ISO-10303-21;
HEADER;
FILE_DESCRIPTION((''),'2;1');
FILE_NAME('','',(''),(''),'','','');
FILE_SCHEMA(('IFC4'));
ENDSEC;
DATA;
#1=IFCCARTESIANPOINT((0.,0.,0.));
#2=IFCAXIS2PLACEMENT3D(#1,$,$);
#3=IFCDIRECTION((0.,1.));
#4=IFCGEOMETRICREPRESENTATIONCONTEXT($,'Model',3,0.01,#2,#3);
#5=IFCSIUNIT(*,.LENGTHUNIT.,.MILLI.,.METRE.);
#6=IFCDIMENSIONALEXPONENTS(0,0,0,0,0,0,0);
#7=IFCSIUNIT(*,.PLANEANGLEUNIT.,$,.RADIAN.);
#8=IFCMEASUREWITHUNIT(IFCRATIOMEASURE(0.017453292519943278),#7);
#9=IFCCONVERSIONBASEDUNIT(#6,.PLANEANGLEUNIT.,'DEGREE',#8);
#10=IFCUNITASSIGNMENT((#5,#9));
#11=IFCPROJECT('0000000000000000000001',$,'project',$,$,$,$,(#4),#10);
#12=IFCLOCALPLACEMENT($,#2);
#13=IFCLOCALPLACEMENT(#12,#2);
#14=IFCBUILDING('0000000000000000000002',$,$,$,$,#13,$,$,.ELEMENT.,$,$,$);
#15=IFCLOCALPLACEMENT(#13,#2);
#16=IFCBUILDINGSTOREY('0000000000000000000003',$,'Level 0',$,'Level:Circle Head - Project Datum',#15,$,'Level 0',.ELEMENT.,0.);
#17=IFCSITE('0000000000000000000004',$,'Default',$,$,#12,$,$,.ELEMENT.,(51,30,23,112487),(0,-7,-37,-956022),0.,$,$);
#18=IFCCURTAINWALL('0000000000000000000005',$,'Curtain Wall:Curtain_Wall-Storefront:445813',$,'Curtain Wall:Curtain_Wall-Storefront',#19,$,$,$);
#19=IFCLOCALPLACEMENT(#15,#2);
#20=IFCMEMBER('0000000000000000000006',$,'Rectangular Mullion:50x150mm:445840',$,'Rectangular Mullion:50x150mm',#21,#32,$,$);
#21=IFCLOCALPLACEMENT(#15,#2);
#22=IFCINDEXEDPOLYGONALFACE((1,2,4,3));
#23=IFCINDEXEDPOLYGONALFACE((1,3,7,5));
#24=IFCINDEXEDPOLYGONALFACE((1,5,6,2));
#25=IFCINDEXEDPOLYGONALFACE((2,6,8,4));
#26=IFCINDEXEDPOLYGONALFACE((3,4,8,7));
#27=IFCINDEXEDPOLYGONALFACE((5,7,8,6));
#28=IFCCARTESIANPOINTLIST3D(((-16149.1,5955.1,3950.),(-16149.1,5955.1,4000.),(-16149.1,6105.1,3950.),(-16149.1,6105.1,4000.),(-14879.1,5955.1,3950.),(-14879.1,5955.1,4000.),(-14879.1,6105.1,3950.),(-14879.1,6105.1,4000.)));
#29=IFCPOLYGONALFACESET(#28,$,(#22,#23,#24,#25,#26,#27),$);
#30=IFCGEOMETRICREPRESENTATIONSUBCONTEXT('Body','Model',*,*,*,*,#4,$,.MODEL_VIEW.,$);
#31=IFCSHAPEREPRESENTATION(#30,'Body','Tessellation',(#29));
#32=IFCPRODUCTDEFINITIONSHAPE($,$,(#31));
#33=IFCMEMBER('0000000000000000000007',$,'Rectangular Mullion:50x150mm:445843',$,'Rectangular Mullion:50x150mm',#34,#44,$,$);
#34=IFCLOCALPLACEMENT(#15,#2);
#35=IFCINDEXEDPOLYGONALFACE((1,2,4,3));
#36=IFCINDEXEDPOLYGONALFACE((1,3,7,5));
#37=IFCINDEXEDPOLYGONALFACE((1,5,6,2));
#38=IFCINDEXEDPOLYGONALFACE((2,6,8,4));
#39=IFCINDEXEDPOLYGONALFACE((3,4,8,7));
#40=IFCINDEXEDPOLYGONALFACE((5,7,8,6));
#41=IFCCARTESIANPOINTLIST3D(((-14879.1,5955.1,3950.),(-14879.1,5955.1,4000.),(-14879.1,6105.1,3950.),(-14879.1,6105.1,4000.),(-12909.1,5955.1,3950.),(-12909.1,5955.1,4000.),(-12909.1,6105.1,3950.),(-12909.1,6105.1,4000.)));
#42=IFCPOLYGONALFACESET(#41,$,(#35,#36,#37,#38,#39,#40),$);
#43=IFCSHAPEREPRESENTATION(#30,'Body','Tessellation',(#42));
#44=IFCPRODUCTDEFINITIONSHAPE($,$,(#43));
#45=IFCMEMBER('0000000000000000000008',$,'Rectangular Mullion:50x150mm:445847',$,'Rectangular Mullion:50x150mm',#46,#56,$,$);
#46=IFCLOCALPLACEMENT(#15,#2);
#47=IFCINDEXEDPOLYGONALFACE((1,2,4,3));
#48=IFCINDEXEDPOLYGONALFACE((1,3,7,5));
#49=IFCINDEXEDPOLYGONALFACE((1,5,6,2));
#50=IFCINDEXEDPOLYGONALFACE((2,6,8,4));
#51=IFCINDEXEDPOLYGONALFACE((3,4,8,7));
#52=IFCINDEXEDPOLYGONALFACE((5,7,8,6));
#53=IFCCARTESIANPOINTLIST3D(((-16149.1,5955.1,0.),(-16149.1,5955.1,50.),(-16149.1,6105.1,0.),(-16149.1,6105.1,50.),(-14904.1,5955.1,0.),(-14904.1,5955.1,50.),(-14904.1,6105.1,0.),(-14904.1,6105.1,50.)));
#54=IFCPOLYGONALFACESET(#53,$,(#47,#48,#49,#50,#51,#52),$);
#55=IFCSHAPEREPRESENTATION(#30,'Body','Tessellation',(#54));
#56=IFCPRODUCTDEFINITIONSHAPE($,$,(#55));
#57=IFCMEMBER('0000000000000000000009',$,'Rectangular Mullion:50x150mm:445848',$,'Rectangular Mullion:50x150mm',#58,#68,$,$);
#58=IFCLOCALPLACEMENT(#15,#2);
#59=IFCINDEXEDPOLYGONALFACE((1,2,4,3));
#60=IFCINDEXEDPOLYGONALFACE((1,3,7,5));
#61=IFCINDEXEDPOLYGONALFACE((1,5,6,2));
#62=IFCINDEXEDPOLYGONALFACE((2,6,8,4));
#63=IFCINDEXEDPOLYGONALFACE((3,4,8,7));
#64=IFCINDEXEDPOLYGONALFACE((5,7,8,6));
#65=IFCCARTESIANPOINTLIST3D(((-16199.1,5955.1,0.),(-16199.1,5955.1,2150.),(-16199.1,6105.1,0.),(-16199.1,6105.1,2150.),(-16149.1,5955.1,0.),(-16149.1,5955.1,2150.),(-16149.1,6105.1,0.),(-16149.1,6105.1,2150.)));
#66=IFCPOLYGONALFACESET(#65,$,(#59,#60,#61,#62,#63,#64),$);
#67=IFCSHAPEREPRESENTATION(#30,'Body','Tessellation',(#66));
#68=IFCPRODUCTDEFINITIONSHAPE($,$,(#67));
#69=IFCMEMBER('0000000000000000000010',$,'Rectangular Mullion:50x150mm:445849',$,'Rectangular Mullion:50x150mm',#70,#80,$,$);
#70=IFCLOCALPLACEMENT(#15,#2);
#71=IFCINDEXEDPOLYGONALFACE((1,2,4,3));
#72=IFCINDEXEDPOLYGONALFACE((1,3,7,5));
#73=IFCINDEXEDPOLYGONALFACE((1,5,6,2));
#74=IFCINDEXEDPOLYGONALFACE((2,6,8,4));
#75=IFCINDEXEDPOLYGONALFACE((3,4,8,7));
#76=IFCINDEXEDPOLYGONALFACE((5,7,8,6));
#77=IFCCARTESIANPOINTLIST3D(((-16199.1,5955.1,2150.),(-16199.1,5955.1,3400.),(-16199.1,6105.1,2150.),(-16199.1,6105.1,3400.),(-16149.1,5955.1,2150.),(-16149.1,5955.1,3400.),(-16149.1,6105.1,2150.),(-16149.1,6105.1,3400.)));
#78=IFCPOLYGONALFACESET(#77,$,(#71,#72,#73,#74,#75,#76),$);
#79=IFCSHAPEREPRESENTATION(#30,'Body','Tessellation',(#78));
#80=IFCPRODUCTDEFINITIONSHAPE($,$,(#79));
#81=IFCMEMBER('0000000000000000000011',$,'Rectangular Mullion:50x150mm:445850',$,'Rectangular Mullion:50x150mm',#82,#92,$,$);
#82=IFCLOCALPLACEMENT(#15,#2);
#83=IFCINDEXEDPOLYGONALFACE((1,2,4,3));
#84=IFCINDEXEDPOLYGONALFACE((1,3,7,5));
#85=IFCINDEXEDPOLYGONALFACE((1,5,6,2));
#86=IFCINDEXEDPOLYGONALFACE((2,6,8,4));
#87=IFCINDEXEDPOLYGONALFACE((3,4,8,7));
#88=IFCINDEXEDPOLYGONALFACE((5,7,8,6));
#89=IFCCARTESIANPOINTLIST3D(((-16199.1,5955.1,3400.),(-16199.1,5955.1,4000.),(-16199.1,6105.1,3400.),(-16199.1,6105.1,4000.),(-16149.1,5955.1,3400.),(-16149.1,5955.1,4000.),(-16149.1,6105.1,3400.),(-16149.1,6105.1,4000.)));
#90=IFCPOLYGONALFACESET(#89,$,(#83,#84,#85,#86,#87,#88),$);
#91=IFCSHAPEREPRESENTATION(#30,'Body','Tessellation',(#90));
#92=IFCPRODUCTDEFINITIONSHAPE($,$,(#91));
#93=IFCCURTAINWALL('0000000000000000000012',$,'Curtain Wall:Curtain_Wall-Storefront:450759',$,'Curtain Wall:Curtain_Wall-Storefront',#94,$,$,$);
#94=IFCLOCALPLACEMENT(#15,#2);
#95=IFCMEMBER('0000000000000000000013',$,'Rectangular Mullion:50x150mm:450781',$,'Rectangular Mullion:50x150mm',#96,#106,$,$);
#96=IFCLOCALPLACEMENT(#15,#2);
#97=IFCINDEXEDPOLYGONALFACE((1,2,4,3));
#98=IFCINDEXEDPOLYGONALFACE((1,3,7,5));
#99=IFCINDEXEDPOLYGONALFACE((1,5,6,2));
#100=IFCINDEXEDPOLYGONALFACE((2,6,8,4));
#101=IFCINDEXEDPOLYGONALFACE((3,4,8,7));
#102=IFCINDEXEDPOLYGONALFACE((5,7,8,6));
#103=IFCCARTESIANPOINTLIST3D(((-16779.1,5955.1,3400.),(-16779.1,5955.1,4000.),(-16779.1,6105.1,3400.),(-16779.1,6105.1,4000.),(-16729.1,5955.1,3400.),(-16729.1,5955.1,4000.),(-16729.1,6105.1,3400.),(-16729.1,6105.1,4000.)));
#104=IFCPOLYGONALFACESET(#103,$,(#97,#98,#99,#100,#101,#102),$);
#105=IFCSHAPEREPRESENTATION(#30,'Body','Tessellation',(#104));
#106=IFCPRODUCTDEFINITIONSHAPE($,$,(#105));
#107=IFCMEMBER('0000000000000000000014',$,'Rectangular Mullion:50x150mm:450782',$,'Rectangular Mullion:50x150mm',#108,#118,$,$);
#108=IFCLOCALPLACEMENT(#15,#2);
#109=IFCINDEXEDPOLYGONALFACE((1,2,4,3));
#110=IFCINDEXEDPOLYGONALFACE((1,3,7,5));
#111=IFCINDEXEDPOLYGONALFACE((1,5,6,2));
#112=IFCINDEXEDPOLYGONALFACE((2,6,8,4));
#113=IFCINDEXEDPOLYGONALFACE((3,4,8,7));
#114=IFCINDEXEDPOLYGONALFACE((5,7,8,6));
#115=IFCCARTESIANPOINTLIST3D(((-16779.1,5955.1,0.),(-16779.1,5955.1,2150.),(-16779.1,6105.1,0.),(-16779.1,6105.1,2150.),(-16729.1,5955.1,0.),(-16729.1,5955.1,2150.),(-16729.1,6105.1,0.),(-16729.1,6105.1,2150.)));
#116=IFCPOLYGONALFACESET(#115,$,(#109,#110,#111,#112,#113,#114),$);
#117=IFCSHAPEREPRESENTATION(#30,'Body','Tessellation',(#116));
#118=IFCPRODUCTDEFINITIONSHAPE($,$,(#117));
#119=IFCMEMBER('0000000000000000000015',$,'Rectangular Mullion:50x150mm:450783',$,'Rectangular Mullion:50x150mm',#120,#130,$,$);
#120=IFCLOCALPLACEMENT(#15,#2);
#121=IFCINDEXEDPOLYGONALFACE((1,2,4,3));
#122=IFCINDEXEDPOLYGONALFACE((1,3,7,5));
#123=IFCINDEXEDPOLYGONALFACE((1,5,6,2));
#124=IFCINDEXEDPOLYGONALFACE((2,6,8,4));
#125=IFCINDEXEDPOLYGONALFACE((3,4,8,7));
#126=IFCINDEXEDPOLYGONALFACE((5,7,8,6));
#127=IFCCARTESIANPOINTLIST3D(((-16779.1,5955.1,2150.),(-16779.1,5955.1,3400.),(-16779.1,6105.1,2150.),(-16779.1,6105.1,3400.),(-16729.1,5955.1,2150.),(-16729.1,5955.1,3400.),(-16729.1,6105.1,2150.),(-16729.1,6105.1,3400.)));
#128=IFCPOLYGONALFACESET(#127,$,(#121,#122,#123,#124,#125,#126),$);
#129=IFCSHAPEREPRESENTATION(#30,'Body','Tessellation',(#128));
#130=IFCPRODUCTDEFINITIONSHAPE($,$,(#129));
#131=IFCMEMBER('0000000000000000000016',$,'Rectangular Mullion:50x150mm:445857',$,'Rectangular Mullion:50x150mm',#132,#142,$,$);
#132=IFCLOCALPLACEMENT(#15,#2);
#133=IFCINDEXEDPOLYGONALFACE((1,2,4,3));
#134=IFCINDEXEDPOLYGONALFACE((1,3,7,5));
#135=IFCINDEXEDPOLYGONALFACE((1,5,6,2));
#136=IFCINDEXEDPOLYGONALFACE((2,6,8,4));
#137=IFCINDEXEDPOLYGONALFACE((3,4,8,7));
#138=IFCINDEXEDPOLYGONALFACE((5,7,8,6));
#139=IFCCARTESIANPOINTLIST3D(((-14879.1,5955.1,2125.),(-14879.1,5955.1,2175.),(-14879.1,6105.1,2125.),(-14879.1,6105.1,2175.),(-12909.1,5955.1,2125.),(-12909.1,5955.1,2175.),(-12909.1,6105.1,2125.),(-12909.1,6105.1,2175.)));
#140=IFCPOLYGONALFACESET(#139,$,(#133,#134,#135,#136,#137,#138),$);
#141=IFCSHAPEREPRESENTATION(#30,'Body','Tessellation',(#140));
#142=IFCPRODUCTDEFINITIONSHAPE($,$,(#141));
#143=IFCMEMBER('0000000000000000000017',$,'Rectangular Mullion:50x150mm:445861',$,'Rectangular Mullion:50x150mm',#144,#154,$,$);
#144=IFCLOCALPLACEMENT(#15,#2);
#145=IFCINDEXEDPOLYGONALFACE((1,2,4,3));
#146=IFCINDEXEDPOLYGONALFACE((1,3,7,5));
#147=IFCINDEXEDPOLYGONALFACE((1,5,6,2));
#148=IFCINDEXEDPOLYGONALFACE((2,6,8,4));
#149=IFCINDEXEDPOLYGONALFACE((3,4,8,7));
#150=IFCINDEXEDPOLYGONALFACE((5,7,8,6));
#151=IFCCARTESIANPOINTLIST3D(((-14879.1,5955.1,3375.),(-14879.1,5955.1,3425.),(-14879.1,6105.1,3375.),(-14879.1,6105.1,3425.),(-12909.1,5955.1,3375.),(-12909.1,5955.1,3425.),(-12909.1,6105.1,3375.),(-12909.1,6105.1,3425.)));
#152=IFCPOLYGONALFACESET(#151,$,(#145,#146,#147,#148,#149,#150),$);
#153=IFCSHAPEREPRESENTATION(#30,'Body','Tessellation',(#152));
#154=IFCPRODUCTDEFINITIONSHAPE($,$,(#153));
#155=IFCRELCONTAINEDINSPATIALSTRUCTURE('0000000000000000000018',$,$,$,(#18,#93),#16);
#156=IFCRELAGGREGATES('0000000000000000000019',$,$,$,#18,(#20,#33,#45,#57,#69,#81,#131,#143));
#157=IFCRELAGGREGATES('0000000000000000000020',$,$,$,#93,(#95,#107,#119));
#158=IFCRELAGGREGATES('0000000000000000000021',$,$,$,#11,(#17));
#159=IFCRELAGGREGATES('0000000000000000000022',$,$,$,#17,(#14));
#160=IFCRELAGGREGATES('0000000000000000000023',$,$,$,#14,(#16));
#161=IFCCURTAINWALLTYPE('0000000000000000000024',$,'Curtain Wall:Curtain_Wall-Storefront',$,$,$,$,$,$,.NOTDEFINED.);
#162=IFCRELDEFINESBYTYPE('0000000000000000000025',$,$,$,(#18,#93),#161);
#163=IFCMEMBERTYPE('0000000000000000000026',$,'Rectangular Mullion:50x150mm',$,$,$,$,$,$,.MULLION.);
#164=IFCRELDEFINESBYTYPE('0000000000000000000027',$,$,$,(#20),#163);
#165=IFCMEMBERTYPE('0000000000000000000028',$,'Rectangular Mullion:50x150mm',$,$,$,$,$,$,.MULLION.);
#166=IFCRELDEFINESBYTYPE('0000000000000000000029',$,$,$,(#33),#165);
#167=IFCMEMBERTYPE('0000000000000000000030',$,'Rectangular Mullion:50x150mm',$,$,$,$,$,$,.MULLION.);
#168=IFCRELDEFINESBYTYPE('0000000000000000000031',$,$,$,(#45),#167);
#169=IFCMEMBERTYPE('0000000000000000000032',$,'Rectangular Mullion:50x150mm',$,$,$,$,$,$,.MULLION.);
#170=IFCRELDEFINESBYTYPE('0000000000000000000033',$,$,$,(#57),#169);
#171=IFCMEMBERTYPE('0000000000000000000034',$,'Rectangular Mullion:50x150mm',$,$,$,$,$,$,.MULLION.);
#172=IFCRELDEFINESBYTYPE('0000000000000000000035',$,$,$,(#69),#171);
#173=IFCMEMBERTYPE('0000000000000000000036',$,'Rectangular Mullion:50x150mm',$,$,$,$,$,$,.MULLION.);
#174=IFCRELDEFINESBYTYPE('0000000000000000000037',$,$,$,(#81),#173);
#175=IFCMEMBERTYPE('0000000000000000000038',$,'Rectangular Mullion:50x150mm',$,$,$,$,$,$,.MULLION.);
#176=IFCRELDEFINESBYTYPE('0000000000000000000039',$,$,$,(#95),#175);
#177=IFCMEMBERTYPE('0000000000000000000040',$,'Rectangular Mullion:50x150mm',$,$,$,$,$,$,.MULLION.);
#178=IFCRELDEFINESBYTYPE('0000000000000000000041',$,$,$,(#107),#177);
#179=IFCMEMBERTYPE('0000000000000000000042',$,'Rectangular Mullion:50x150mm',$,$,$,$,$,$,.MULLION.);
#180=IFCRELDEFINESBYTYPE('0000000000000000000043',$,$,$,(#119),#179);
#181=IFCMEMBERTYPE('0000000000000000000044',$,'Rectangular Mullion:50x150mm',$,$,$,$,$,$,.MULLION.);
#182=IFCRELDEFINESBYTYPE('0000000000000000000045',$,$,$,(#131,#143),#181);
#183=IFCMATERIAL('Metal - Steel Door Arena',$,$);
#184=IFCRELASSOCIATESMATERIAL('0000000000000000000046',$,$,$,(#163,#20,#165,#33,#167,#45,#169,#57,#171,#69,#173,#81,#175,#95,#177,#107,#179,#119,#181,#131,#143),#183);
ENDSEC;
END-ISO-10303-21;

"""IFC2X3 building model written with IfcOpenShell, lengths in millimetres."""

from ifc_helpers import new_model, entity, si_unit, converted_unit, direction, frame, origin, origin_2d_with_axis, place, context, subcontext, project, spatial, rectangle, extrude, source, transform, mapped, material, type_object, type_shapes, element, aggregate, save


model = new_model("IFC2X3")

# Units and contexts
model_context = context("Model", 3, precision=0.01, world=origin(), true_north=direction((0.0, 1.0)))
body_context = subcontext(model_context, "Body", "Model", "MODEL_VIEW")
ifc_project = project(units=[si_unit("LENGTHUNIT", "METRE", prefix="MILLI"), converted_unit("PLANEANGLEUNIT", "DEGREE", entity("IfcRatioMeasure", 0.017453292519943278), si_unit("PLANEANGLEUNIT", "RADIAN"), dimensions=[0, 0, 0, 0, 0, 0, 0])], contexts=[model_context])

# Site, building, storey
site_placement = place(None, origin())
site = spatial("IfcSite", under=ifc_project, at=site_placement, Name="Default", CompositionType="ELEMENT", RefLatitude=(51, 30, 23, 112487), RefLongitude=(0, -7, -37, -956022), RefElevation=0.0)
building_placement = place(site_placement, origin())
building = spatial("IfcBuilding", under=site, at=building_placement, CompositionType="ELEMENT")
storey_placement = place(building_placement, origin())
storey = spatial("IfcBuildingStorey", under=building, at=storey_placement, Name="Level 0", ObjectType="Level:Circle Head - Project Datum", LongName="Level 0", CompositionType="ELEMENT", Elevation=0.0)

# Curtain walls, members
curtain_wall_type = type_object("IfcCurtainWallType", Name="Curtain Wall:Curtain_Wall-Storefront", PredefinedType="NOTDEFINED")
curtain_wall_1_placement = place(storey_placement, origin())
curtain_wall_1 = element("IfcCurtainWall", 1, at=curtain_wall_1_placement, inside=storey, type_object=curtain_wall_type, Name="Curtain Wall:Curtain_Wall-Storefront:445813", ObjectType="Curtain Wall:Curtain_Wall-Storefront")
ifc_material_1 = material(Name="Metal - Steel Door Arena")
member_type_1 = type_object("IfcMemberType", Name="Rectangular Mullion:50x150mm", PredefinedType="MULLION", material=ifc_material_1)
shared_shape_1 = source(origin(), body_context, "Body", "SweptSolid", [
    extrude(rectangle(XDim=150.0, YDim=50.0, at=origin_2d_with_axis()), frame((-25.0, 0.0, -1270.0), z_axis=(0.0, 0.0, 1.0), x_axis=(0.0, -1.0, 0.0)), (0.0, 0.0, 1.0), 1270.0),
])
type_shapes(member_type_1, [shared_shape_1])
member_1_placement = place(curtain_wall_1_placement, frame((-16149.1, 6030.1, 4000.0), z_axis=(-1.0, 0.0, 0.0), x_axis=(0.0, 0.0, 1.0)))
member_1 = element("IfcMember", 2, at=member_1_placement, type_object=member_type_1, material=ifc_material_1, Name="Rectangular Mullion:50x150mm:445840", ObjectType="Rectangular Mullion:50x150mm", context=body_context, shape_type="MappedRepresentation", body=[
    mapped(shared_shape_1, transform((0.0, 0.0, 0.0), scale=1.0)),
])
member_type_2 = type_object("IfcMemberType", Name="Rectangular Mullion:50x150mm", PredefinedType="MULLION", material=ifc_material_1)
shared_shape_2 = source(origin(), body_context, "Body", "SweptSolid", [
    extrude(rectangle(XDim=150.0, YDim=50.0, at=origin_2d_with_axis()), frame((-25.0, 0.0, -1970.0), z_axis=(0.0, 0.0, 1.0), x_axis=(0.0, -1.0, 0.0)), (0.0, 0.0, 1.0), 1970.0),
])
type_shapes(member_type_2, [shared_shape_2])
member_2_placement = place(curtain_wall_1_placement, frame((-14879.1, 6030.1, 4000.0), z_axis=(-1.0, 0.0, 0.0), x_axis=(0.0, 0.0, 1.0)))
member_2 = element("IfcMember", 3, at=member_2_placement, type_object=member_type_2, material=ifc_material_1, Name="Rectangular Mullion:50x150mm:445843", ObjectType="Rectangular Mullion:50x150mm", context=body_context, shape_type="MappedRepresentation", body=[
    mapped(shared_shape_2, transform((0.0, 0.0, 0.0), scale=1.0)),
])
member_type_3 = type_object("IfcMemberType", Name="Rectangular Mullion:50x150mm", PredefinedType="MULLION", material=ifc_material_1)
shared_shape_3 = source(origin(), body_context, "Body", "SweptSolid", [
    extrude(rectangle(XDim=150.0, YDim=50.0, at=origin_2d_with_axis()), frame((-25.0, 0.0, -1245.0), z_axis=(0.0, 0.0, 1.0), x_axis=(0.0, -1.0, 0.0)), (0.0, 0.0, 1.0), 1245.0),
])
type_shapes(member_type_3, [shared_shape_3])
member_3_placement = place(curtain_wall_1_placement, frame((-14904.1, 6030.1, 0.0), z_axis=(1.0, 0.0, 0.0), x_axis=(0.0, 0.0, -1.0)))
member_3 = element("IfcMember", 4, at=member_3_placement, type_object=member_type_3, material=ifc_material_1, Name="Rectangular Mullion:50x150mm:445847", ObjectType="Rectangular Mullion:50x150mm", context=body_context, shape_type="MappedRepresentation", body=[
    mapped(shared_shape_3, transform((0.0, 0.0, 0.0), scale=1.0)),
])
member_type_4 = type_object("IfcMemberType", Name="Rectangular Mullion:50x150mm", PredefinedType="MULLION", material=ifc_material_1)
shared_shape_4 = source(origin(), body_context, "Body", "SweptSolid", [
    extrude(rectangle(XDim=150.0, YDim=50.0, at=origin_2d_with_axis()), frame((-25.0, 0.0, -2150.0), z_axis=(0.0, 0.0, 1.0), x_axis=(0.0, -1.0, 0.0)), (0.0, 0.0, 1.0), 2150.0),
])
type_shapes(member_type_4, [shared_shape_4])
member_4_placement = place(curtain_wall_1_placement, frame((-16199.1, 6030.1, 0.0), z_axis=(0.0, 0.0, -1.0), x_axis=(-1.0, 0.0, 0.0)))
member_4 = element("IfcMember", 5, at=member_4_placement, type_object=member_type_4, material=ifc_material_1, Name="Rectangular Mullion:50x150mm:445848", ObjectType="Rectangular Mullion:50x150mm", context=body_context, shape_type="MappedRepresentation", body=[
    mapped(shared_shape_4, transform((0.0, 0.0, 0.0), scale=1.0)),
])
member_type_5 = type_object("IfcMemberType", Name="Rectangular Mullion:50x150mm", PredefinedType="MULLION", material=ifc_material_1)
shared_shape_5 = source(origin(), body_context, "Body", "SweptSolid", [
    extrude(rectangle(XDim=150.0, YDim=50.0, at=origin_2d_with_axis()), frame((-25.0, 0.0, -1250.0), z_axis=(0.0, 0.0, 1.0), x_axis=(0.0, -1.0, 0.0)), (0.0, 0.0, 1.0), 1250.0),
])
type_shapes(member_type_5, [shared_shape_5])
member_5_placement = place(curtain_wall_1_placement, frame((-16199.1, 6030.1, 2150.0), z_axis=(0.0, 0.0, -1.0), x_axis=(-1.0, 0.0, 0.0)))
member_5 = element("IfcMember", 6, at=member_5_placement, type_object=member_type_5, material=ifc_material_1, Name="Rectangular Mullion:50x150mm:445849", ObjectType="Rectangular Mullion:50x150mm", context=body_context, shape_type="MappedRepresentation", body=[
    mapped(shared_shape_5, transform((0.0, 0.0, 0.0), scale=1.0)),
])
member_type_6 = type_object("IfcMemberType", Name="Rectangular Mullion:50x150mm", PredefinedType="MULLION", material=ifc_material_1)
shared_shape_6 = source(origin(), body_context, "Body", "SweptSolid", [
    extrude(rectangle(XDim=150.0, YDim=50.0, at=origin_2d_with_axis()), frame((-25.0, 0.0, -600.0), z_axis=(0.0, 0.0, 1.0), x_axis=(0.0, -1.0, 0.0)), (0.0, 0.0, 1.0), 600.0),
])
type_shapes(member_type_6, [shared_shape_6])
member_6_placement = place(curtain_wall_1_placement, frame((-16199.1, 6030.1, 3400.0), z_axis=(0.0, 0.0, -1.0), x_axis=(-1.0, 0.0, 0.0)))
member_6 = element("IfcMember", 7, at=member_6_placement, type_object=member_type_6, material=ifc_material_1, Name="Rectangular Mullion:50x150mm:445850", ObjectType="Rectangular Mullion:50x150mm", context=body_context, shape_type="MappedRepresentation", body=[
    mapped(shared_shape_6, transform((0.0, 0.0, 0.0), scale=1.0)),
])
curtain_wall_2_placement = place(storey_placement, origin())
curtain_wall_2 = element("IfcCurtainWall", 8, at=curtain_wall_2_placement, inside=storey, type_object=curtain_wall_type, Name="Curtain Wall:Curtain_Wall-Storefront:450759", ObjectType="Curtain Wall:Curtain_Wall-Storefront")
member_type_7 = type_object("IfcMemberType", Name="Rectangular Mullion:50x150mm", PredefinedType="MULLION", material=ifc_material_1)
shared_shape_7 = source(origin(), body_context, "Body", "SweptSolid", [
    extrude(rectangle(XDim=150.0, YDim=50.0, at=origin_2d_with_axis()), frame((-25.0, 0.0, -600.0), z_axis=(0.0, 0.0, 1.0), x_axis=(0.0, -1.0, 0.0)), (0.0, 0.0, 1.0), 600.0),
])
type_shapes(member_type_7, [shared_shape_7])
member_7_placement = place(curtain_wall_2_placement, frame((-16729.1, 6030.1, 4000.0)))
member_7 = element("IfcMember", 9, at=member_7_placement, type_object=member_type_7, material=ifc_material_1, Name="Rectangular Mullion:50x150mm:450781", ObjectType="Rectangular Mullion:50x150mm", context=body_context, shape_type="MappedRepresentation", body=[
    mapped(shared_shape_7, transform((0.0, 0.0, 0.0), scale=1.0)),
])
member_type_8 = type_object("IfcMemberType", Name="Rectangular Mullion:50x150mm", PredefinedType="MULLION", material=ifc_material_1)
shared_shape_8 = source(origin(), body_context, "Body", "SweptSolid", [
    extrude(rectangle(XDim=150.0, YDim=50.0, at=origin_2d_with_axis()), frame((-25.0, 0.0, -2150.0), z_axis=(0.0, 0.0, 1.0), x_axis=(0.0, -1.0, 0.0)), (0.0, 0.0, 1.0), 2150.0),
])
type_shapes(member_type_8, [shared_shape_8])
member_8_placement = place(curtain_wall_2_placement, frame((-16729.1, 6030.1, 2150.0)))
member_8 = element("IfcMember", 10, at=member_8_placement, type_object=member_type_8, material=ifc_material_1, Name="Rectangular Mullion:50x150mm:450782", ObjectType="Rectangular Mullion:50x150mm", context=body_context, shape_type="MappedRepresentation", body=[
    mapped(shared_shape_8, transform((0.0, 0.0, 0.0), scale=1.0)),
])
member_type_9 = type_object("IfcMemberType", Name="Rectangular Mullion:50x150mm", PredefinedType="MULLION", material=ifc_material_1)
shared_shape_9 = source(origin(), body_context, "Body", "SweptSolid", [
    extrude(rectangle(XDim=150.0, YDim=50.0, at=origin_2d_with_axis()), frame((-25.0, 0.0, -1250.0), z_axis=(0.0, 0.0, 1.0), x_axis=(0.0, -1.0, 0.0)), (0.0, 0.0, 1.0), 1250.0),
])
type_shapes(member_type_9, [shared_shape_9])
member_9_placement = place(curtain_wall_2_placement, frame((-16729.1, 6030.1, 3400.0)))
member_9 = element("IfcMember", 11, at=member_9_placement, type_object=member_type_9, material=ifc_material_1, Name="Rectangular Mullion:50x150mm:450783", ObjectType="Rectangular Mullion:50x150mm", context=body_context, shape_type="MappedRepresentation", body=[
    mapped(shared_shape_9, transform((0.0, 0.0, 0.0), scale=1.0)),
])

# Members
member_type_10 = type_object("IfcMemberType", Name="Rectangular Mullion:50x150mm", PredefinedType="MULLION", material=ifc_material_1)
shared_shape_10 = source(origin(), body_context, "Body", "SweptSolid", [
    extrude(rectangle(XDim=150.0, YDim=50.0, at=origin_2d_with_axis()), frame((0.0, 0.0, -1970.0), z_axis=(0.0, 0.0, 1.0), x_axis=(0.0, -1.0, 0.0)), (0.0, 0.0, 1.0), 1970.0),
])
type_shapes(member_type_10, [shared_shape_10])
member_10_placement = place(curtain_wall_1_placement, frame((-14879.1, 6030.1, 2150.0), z_axis=(-1.0, 0.0, 0.0), x_axis=(0.0, 0.0, 1.0)))
member_10 = element("IfcMember", 12, at=member_10_placement, type_object=member_type_10, material=ifc_material_1, Name="Rectangular Mullion:50x150mm:445857", ObjectType="Rectangular Mullion:50x150mm", context=body_context, shape_type="MappedRepresentation", body=[
    mapped(shared_shape_10, transform((0.0, 0.0, 0.0), scale=1.0)),
])
member_11_placement = place(curtain_wall_1_placement, frame((-14879.1, 6030.1, 3400.0), z_axis=(-1.0, 0.0, 0.0), x_axis=(0.0, 0.0, 1.0)))
member_11 = element("IfcMember", 13, at=member_11_placement, type_object=member_type_10, material=ifc_material_1, Name="Rectangular Mullion:50x150mm:445861", ObjectType="Rectangular Mullion:50x150mm", context=body_context, shape_type="MappedRepresentation", body=[
    mapped(shared_shape_10, transform((0.0, 0.0, 0.0), scale=1.0)),
])

aggregate(curtain_wall_1, [member_1, member_2, member_3, member_4, member_5, member_6, member_10, member_11])
aggregate(curtain_wall_2, [member_7, member_8, member_9])

save(model, "model.ifc")
